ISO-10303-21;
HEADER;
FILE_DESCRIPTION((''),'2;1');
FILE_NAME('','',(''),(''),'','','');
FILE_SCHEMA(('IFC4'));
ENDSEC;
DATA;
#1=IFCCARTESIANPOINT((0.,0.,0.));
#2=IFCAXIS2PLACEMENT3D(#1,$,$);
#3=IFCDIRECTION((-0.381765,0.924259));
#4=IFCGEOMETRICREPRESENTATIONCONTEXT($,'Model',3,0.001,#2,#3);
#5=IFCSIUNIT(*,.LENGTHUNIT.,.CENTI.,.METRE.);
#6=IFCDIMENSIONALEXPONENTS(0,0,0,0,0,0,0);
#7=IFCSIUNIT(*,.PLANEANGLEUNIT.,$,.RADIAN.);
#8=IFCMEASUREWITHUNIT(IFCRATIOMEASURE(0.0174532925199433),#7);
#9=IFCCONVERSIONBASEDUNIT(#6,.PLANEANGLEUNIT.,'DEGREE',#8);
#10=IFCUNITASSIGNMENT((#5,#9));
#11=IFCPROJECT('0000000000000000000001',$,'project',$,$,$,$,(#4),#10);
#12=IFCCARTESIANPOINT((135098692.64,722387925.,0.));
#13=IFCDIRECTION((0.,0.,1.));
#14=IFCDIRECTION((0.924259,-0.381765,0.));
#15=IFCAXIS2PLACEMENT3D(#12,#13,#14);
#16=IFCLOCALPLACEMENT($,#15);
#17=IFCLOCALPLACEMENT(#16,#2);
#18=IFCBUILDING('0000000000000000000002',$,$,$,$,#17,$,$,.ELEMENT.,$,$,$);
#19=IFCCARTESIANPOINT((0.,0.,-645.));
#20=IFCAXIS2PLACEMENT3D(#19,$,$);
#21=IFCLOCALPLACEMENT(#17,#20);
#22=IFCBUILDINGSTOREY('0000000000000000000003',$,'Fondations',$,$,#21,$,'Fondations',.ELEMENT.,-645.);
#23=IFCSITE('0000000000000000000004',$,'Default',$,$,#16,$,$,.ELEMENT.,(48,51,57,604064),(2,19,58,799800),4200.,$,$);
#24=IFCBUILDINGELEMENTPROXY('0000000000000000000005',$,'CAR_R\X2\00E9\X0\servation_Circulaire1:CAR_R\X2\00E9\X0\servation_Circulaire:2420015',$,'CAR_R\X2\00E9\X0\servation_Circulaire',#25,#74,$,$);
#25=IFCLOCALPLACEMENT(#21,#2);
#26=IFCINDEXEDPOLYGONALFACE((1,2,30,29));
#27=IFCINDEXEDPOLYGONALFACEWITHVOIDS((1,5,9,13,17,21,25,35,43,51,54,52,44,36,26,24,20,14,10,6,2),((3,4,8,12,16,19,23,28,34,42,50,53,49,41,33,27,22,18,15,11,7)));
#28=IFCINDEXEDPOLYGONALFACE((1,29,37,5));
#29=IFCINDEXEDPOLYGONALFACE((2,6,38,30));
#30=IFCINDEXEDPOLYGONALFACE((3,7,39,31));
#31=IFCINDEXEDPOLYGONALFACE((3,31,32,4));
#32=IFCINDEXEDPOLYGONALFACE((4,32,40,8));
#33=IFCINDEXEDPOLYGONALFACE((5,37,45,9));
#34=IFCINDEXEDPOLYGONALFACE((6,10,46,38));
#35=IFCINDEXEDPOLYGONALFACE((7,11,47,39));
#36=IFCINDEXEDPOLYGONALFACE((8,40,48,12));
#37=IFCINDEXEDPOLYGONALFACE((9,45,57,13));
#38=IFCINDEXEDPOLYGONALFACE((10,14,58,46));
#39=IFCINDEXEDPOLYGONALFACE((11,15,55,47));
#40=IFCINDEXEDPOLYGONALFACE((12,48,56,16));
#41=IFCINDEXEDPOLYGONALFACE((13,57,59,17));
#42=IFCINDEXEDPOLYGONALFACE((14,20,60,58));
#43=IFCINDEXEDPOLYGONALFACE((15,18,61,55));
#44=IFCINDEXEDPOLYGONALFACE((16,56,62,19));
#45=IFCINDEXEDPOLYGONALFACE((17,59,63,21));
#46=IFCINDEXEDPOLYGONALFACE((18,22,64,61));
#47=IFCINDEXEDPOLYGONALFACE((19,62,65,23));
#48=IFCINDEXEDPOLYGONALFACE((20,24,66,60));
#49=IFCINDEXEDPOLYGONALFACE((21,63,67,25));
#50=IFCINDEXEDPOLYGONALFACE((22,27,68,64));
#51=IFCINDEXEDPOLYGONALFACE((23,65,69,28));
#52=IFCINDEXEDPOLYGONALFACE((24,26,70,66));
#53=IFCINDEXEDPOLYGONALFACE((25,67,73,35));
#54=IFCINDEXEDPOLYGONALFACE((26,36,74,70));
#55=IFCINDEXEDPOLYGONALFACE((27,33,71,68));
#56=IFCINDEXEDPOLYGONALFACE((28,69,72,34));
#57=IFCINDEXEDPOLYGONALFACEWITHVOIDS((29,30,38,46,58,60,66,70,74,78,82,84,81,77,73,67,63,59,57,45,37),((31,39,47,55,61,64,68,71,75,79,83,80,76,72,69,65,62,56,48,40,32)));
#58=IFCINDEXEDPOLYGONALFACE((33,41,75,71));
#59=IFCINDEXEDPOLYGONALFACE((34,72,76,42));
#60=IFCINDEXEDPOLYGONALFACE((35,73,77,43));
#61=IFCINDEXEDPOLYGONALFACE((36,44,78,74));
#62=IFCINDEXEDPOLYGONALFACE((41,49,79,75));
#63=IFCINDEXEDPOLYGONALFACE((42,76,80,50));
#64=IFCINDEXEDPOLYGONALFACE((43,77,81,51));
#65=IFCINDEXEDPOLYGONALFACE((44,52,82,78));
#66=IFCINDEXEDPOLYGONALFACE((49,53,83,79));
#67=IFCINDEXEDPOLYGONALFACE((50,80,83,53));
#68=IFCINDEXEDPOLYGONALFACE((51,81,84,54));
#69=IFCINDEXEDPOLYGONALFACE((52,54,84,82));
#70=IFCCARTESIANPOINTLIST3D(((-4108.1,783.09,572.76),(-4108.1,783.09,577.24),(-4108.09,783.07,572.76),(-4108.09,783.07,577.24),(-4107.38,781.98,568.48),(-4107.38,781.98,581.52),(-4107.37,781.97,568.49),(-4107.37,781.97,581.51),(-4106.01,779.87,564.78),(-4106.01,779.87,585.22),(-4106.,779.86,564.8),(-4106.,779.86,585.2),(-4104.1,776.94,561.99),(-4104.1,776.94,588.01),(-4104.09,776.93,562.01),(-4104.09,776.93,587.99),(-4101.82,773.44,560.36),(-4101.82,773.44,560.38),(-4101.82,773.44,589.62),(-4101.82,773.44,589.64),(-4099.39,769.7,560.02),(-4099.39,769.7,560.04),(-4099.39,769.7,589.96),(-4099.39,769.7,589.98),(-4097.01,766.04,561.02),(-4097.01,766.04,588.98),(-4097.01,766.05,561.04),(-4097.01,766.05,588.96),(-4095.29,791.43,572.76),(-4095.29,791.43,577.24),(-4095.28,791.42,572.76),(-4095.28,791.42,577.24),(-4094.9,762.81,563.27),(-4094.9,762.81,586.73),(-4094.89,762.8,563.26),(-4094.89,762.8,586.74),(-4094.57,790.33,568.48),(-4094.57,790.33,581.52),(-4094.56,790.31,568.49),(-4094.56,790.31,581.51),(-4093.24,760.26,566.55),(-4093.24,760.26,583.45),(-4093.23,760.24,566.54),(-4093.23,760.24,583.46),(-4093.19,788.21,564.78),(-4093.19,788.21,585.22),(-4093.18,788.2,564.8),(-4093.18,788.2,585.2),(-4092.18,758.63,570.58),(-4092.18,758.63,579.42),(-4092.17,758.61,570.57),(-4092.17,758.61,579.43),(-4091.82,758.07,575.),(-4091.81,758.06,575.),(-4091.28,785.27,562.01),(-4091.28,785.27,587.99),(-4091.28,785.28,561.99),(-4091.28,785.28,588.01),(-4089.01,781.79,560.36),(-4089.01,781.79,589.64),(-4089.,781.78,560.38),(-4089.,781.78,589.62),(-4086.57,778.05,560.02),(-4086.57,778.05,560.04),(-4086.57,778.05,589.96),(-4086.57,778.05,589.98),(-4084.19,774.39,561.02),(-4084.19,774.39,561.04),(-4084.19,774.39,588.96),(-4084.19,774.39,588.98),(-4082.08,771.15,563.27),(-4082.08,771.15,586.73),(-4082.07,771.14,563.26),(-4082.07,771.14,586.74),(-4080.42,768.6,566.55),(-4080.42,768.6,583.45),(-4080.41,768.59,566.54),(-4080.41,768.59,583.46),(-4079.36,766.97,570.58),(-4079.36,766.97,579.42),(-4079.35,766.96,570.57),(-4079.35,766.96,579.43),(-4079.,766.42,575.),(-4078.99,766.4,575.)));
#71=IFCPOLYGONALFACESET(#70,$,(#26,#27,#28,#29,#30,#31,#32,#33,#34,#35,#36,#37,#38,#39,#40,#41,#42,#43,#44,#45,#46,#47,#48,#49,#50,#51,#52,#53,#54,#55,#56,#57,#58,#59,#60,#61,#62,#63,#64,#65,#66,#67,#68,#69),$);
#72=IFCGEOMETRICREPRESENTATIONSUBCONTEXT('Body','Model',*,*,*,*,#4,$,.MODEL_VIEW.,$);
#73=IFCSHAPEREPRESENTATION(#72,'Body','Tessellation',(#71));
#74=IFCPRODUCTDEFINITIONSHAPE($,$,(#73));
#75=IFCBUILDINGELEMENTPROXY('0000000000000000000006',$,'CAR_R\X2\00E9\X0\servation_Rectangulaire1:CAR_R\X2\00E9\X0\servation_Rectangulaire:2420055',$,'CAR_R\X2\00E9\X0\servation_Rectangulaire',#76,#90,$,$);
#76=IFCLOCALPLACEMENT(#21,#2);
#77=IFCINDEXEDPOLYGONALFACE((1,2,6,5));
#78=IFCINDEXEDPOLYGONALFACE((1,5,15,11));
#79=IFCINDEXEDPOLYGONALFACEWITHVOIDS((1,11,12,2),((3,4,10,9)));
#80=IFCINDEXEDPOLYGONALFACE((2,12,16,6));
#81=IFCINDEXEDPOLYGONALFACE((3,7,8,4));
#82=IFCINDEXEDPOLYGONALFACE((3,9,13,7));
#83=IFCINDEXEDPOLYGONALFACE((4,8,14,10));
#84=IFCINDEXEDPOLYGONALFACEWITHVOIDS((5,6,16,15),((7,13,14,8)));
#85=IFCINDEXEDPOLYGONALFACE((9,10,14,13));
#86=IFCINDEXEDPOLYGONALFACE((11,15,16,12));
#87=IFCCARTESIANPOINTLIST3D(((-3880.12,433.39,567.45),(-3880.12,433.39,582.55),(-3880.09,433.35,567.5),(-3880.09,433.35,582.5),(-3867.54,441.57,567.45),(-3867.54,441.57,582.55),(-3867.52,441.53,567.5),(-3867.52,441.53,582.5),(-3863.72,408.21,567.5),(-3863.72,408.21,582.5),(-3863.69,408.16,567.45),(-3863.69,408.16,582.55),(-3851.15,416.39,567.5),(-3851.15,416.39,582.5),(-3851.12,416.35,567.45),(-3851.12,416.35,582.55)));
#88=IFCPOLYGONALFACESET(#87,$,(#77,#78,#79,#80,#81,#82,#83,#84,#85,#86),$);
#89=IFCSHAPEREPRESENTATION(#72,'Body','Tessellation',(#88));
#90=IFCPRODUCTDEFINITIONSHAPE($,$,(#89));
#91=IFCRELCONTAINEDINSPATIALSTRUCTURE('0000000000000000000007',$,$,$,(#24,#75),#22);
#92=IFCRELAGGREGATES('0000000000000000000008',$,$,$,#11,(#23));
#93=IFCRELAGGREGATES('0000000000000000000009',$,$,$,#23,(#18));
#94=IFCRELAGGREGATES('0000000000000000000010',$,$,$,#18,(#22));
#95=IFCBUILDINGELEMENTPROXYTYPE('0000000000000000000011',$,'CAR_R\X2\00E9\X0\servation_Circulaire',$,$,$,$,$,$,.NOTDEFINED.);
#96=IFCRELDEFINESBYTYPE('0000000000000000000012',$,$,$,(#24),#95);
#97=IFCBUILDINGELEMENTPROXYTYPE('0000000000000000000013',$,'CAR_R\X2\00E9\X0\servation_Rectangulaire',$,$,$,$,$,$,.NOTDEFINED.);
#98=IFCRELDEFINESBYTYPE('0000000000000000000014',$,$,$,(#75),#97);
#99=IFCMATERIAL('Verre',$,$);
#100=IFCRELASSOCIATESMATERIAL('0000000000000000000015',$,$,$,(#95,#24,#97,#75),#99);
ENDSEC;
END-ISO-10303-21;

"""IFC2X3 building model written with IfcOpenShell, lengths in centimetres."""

from ifc_helpers import new_model, entity, si_unit, converted_unit, direction, frame, frame_2d, origin, place, context, subcontext, project, spatial, polyline, hollow_circle, outline, extrude, source, transform, mapped, material, type_object, type_shapes, element, save


model = new_model("IFC2X3")

# Units and contexts
model_context = context("Model", 3, precision=0.001, world=origin(), true_north=direction((-0.381765, 0.924259)))
body_context = subcontext(model_context, "Body", "Model", "MODEL_VIEW")
ifc_project = project(units=[si_unit("LENGTHUNIT", "METRE", prefix="CENTI"), converted_unit("PLANEANGLEUNIT", "DEGREE", entity("IfcRatioMeasure", 0.0174532925199433), si_unit("PLANEANGLEUNIT", "RADIAN"), dimensions=[0, 0, 0, 0, 0, 0, 0])], contexts=[model_context])

# Site, building, storey
site_placement = place(None, frame((135098692.64, 722387925.0, 0.0), z_axis=(0.0, 0.0, 1.0), x_axis=(0.924259, -0.381765, 0.0)))
site = spatial("IfcSite", under=ifc_project, at=site_placement, Name="Default", CompositionType="ELEMENT", RefLatitude=(48, 51, 57, 604064), RefLongitude=(2, 19, 58, 799800), RefElevation=4200.0)
building_placement = place(site_placement, origin())
building = spatial("IfcBuilding", under=site, at=building_placement, CompositionType="ELEMENT")
storey_placement = place(building_placement, frame((0.0, 0.0, -645.0)))
storey = spatial("IfcBuildingStorey", under=building, at=storey_placement, Name="Fondations", LongName="Fondations", CompositionType="ELEMENT", Elevation=-645.0)

# Building element proxies
ifc_material_1 = material(Name="Verre")
building_element_proxy_type_1 = type_object("IfcBuildingElementProxyType", Name="CAR_Réservation_Circulaire", PredefinedType="NOTDEFINED", material=ifc_material_1)
shared_shape_1 = source(origin(), body_context, "Body", "SweptSolid", [
    extrude(hollow_circle(Radius=15.02, WallThickness=0.02, at=frame_2d((0.0, 0.0), x_axis=(1.0, 0.0))), frame((0.0, 0.0, -15.0)), (0.0, 0.0, 1.0), 15.29),
])
type_shapes(building_element_proxy_type_1, [shared_shape_1])
proxy_1_placement = place(storey_placement, frame((-4099.75, 770.8, 575.0), z_axis=(-0.83808, -0.545548, 0.0), x_axis=(0.545548, -0.83808, 0.0)))
element("IfcBuildingElementProxy", 1, at=proxy_1_placement, inside=storey, type_object=building_element_proxy_type_1, material=ifc_material_1, Name="CAR_Réservation_Circulaire1:CAR_Réservation_Circulaire:2420015", ObjectType="CAR_Réservation_Circulaire", context=body_context, shape_type="MappedRepresentation", body=[
    mapped(shared_shape_1, transform((0.0, 0.0, 0.0), scale=1.0)),
])
building_element_proxy_type_2 = type_object("IfcBuildingElementProxyType", Name="CAR_Réservation_Rectangulaire", PredefinedType="NOTDEFINED", material=ifc_material_1)
shared_shape_2 = source(origin(), body_context, "Body", "SweptSolid", [
    extrude(outline(polyline([(-15.05, -7.55), (15.05, -7.55), (15.05, 7.55), (-15.05, 7.55), (-15.05, -7.55)]), holes=[polyline([(15.0, -7.5), (-15.0, -7.5), (-15.0, 7.5), (15.0, 7.5), (15.0, -7.5)])]), frame((0.0, 0.0, -15.0), z_axis=(0.0, 0.0, 1.0), x_axis=(-1.0, 0.0, 0.0)), (0.0, 0.0, 1.0), 15.0),
])
type_shapes(building_element_proxy_type_2, [shared_shape_2])
proxy_2_placement = place(storey_placement, frame((-3859.33, 428.96, 575.0), z_axis=(0.83808, 0.545548, 0.0), x_axis=(-0.545548, 0.83808, 0.0)))
element("IfcBuildingElementProxy", 2, at=proxy_2_placement, inside=storey, type_object=building_element_proxy_type_2, material=ifc_material_1, Name="CAR_Réservation_Rectangulaire1:CAR_Réservation_Rectangulaire:2420055", ObjectType="CAR_Réservation_Rectangulaire", context=body_context, shape_type="MappedRepresentation", body=[
    mapped(shared_shape_2, transform((0.0, 0.0, 0.0), scale=1.0)),
])

save(model, "model.ifc")
